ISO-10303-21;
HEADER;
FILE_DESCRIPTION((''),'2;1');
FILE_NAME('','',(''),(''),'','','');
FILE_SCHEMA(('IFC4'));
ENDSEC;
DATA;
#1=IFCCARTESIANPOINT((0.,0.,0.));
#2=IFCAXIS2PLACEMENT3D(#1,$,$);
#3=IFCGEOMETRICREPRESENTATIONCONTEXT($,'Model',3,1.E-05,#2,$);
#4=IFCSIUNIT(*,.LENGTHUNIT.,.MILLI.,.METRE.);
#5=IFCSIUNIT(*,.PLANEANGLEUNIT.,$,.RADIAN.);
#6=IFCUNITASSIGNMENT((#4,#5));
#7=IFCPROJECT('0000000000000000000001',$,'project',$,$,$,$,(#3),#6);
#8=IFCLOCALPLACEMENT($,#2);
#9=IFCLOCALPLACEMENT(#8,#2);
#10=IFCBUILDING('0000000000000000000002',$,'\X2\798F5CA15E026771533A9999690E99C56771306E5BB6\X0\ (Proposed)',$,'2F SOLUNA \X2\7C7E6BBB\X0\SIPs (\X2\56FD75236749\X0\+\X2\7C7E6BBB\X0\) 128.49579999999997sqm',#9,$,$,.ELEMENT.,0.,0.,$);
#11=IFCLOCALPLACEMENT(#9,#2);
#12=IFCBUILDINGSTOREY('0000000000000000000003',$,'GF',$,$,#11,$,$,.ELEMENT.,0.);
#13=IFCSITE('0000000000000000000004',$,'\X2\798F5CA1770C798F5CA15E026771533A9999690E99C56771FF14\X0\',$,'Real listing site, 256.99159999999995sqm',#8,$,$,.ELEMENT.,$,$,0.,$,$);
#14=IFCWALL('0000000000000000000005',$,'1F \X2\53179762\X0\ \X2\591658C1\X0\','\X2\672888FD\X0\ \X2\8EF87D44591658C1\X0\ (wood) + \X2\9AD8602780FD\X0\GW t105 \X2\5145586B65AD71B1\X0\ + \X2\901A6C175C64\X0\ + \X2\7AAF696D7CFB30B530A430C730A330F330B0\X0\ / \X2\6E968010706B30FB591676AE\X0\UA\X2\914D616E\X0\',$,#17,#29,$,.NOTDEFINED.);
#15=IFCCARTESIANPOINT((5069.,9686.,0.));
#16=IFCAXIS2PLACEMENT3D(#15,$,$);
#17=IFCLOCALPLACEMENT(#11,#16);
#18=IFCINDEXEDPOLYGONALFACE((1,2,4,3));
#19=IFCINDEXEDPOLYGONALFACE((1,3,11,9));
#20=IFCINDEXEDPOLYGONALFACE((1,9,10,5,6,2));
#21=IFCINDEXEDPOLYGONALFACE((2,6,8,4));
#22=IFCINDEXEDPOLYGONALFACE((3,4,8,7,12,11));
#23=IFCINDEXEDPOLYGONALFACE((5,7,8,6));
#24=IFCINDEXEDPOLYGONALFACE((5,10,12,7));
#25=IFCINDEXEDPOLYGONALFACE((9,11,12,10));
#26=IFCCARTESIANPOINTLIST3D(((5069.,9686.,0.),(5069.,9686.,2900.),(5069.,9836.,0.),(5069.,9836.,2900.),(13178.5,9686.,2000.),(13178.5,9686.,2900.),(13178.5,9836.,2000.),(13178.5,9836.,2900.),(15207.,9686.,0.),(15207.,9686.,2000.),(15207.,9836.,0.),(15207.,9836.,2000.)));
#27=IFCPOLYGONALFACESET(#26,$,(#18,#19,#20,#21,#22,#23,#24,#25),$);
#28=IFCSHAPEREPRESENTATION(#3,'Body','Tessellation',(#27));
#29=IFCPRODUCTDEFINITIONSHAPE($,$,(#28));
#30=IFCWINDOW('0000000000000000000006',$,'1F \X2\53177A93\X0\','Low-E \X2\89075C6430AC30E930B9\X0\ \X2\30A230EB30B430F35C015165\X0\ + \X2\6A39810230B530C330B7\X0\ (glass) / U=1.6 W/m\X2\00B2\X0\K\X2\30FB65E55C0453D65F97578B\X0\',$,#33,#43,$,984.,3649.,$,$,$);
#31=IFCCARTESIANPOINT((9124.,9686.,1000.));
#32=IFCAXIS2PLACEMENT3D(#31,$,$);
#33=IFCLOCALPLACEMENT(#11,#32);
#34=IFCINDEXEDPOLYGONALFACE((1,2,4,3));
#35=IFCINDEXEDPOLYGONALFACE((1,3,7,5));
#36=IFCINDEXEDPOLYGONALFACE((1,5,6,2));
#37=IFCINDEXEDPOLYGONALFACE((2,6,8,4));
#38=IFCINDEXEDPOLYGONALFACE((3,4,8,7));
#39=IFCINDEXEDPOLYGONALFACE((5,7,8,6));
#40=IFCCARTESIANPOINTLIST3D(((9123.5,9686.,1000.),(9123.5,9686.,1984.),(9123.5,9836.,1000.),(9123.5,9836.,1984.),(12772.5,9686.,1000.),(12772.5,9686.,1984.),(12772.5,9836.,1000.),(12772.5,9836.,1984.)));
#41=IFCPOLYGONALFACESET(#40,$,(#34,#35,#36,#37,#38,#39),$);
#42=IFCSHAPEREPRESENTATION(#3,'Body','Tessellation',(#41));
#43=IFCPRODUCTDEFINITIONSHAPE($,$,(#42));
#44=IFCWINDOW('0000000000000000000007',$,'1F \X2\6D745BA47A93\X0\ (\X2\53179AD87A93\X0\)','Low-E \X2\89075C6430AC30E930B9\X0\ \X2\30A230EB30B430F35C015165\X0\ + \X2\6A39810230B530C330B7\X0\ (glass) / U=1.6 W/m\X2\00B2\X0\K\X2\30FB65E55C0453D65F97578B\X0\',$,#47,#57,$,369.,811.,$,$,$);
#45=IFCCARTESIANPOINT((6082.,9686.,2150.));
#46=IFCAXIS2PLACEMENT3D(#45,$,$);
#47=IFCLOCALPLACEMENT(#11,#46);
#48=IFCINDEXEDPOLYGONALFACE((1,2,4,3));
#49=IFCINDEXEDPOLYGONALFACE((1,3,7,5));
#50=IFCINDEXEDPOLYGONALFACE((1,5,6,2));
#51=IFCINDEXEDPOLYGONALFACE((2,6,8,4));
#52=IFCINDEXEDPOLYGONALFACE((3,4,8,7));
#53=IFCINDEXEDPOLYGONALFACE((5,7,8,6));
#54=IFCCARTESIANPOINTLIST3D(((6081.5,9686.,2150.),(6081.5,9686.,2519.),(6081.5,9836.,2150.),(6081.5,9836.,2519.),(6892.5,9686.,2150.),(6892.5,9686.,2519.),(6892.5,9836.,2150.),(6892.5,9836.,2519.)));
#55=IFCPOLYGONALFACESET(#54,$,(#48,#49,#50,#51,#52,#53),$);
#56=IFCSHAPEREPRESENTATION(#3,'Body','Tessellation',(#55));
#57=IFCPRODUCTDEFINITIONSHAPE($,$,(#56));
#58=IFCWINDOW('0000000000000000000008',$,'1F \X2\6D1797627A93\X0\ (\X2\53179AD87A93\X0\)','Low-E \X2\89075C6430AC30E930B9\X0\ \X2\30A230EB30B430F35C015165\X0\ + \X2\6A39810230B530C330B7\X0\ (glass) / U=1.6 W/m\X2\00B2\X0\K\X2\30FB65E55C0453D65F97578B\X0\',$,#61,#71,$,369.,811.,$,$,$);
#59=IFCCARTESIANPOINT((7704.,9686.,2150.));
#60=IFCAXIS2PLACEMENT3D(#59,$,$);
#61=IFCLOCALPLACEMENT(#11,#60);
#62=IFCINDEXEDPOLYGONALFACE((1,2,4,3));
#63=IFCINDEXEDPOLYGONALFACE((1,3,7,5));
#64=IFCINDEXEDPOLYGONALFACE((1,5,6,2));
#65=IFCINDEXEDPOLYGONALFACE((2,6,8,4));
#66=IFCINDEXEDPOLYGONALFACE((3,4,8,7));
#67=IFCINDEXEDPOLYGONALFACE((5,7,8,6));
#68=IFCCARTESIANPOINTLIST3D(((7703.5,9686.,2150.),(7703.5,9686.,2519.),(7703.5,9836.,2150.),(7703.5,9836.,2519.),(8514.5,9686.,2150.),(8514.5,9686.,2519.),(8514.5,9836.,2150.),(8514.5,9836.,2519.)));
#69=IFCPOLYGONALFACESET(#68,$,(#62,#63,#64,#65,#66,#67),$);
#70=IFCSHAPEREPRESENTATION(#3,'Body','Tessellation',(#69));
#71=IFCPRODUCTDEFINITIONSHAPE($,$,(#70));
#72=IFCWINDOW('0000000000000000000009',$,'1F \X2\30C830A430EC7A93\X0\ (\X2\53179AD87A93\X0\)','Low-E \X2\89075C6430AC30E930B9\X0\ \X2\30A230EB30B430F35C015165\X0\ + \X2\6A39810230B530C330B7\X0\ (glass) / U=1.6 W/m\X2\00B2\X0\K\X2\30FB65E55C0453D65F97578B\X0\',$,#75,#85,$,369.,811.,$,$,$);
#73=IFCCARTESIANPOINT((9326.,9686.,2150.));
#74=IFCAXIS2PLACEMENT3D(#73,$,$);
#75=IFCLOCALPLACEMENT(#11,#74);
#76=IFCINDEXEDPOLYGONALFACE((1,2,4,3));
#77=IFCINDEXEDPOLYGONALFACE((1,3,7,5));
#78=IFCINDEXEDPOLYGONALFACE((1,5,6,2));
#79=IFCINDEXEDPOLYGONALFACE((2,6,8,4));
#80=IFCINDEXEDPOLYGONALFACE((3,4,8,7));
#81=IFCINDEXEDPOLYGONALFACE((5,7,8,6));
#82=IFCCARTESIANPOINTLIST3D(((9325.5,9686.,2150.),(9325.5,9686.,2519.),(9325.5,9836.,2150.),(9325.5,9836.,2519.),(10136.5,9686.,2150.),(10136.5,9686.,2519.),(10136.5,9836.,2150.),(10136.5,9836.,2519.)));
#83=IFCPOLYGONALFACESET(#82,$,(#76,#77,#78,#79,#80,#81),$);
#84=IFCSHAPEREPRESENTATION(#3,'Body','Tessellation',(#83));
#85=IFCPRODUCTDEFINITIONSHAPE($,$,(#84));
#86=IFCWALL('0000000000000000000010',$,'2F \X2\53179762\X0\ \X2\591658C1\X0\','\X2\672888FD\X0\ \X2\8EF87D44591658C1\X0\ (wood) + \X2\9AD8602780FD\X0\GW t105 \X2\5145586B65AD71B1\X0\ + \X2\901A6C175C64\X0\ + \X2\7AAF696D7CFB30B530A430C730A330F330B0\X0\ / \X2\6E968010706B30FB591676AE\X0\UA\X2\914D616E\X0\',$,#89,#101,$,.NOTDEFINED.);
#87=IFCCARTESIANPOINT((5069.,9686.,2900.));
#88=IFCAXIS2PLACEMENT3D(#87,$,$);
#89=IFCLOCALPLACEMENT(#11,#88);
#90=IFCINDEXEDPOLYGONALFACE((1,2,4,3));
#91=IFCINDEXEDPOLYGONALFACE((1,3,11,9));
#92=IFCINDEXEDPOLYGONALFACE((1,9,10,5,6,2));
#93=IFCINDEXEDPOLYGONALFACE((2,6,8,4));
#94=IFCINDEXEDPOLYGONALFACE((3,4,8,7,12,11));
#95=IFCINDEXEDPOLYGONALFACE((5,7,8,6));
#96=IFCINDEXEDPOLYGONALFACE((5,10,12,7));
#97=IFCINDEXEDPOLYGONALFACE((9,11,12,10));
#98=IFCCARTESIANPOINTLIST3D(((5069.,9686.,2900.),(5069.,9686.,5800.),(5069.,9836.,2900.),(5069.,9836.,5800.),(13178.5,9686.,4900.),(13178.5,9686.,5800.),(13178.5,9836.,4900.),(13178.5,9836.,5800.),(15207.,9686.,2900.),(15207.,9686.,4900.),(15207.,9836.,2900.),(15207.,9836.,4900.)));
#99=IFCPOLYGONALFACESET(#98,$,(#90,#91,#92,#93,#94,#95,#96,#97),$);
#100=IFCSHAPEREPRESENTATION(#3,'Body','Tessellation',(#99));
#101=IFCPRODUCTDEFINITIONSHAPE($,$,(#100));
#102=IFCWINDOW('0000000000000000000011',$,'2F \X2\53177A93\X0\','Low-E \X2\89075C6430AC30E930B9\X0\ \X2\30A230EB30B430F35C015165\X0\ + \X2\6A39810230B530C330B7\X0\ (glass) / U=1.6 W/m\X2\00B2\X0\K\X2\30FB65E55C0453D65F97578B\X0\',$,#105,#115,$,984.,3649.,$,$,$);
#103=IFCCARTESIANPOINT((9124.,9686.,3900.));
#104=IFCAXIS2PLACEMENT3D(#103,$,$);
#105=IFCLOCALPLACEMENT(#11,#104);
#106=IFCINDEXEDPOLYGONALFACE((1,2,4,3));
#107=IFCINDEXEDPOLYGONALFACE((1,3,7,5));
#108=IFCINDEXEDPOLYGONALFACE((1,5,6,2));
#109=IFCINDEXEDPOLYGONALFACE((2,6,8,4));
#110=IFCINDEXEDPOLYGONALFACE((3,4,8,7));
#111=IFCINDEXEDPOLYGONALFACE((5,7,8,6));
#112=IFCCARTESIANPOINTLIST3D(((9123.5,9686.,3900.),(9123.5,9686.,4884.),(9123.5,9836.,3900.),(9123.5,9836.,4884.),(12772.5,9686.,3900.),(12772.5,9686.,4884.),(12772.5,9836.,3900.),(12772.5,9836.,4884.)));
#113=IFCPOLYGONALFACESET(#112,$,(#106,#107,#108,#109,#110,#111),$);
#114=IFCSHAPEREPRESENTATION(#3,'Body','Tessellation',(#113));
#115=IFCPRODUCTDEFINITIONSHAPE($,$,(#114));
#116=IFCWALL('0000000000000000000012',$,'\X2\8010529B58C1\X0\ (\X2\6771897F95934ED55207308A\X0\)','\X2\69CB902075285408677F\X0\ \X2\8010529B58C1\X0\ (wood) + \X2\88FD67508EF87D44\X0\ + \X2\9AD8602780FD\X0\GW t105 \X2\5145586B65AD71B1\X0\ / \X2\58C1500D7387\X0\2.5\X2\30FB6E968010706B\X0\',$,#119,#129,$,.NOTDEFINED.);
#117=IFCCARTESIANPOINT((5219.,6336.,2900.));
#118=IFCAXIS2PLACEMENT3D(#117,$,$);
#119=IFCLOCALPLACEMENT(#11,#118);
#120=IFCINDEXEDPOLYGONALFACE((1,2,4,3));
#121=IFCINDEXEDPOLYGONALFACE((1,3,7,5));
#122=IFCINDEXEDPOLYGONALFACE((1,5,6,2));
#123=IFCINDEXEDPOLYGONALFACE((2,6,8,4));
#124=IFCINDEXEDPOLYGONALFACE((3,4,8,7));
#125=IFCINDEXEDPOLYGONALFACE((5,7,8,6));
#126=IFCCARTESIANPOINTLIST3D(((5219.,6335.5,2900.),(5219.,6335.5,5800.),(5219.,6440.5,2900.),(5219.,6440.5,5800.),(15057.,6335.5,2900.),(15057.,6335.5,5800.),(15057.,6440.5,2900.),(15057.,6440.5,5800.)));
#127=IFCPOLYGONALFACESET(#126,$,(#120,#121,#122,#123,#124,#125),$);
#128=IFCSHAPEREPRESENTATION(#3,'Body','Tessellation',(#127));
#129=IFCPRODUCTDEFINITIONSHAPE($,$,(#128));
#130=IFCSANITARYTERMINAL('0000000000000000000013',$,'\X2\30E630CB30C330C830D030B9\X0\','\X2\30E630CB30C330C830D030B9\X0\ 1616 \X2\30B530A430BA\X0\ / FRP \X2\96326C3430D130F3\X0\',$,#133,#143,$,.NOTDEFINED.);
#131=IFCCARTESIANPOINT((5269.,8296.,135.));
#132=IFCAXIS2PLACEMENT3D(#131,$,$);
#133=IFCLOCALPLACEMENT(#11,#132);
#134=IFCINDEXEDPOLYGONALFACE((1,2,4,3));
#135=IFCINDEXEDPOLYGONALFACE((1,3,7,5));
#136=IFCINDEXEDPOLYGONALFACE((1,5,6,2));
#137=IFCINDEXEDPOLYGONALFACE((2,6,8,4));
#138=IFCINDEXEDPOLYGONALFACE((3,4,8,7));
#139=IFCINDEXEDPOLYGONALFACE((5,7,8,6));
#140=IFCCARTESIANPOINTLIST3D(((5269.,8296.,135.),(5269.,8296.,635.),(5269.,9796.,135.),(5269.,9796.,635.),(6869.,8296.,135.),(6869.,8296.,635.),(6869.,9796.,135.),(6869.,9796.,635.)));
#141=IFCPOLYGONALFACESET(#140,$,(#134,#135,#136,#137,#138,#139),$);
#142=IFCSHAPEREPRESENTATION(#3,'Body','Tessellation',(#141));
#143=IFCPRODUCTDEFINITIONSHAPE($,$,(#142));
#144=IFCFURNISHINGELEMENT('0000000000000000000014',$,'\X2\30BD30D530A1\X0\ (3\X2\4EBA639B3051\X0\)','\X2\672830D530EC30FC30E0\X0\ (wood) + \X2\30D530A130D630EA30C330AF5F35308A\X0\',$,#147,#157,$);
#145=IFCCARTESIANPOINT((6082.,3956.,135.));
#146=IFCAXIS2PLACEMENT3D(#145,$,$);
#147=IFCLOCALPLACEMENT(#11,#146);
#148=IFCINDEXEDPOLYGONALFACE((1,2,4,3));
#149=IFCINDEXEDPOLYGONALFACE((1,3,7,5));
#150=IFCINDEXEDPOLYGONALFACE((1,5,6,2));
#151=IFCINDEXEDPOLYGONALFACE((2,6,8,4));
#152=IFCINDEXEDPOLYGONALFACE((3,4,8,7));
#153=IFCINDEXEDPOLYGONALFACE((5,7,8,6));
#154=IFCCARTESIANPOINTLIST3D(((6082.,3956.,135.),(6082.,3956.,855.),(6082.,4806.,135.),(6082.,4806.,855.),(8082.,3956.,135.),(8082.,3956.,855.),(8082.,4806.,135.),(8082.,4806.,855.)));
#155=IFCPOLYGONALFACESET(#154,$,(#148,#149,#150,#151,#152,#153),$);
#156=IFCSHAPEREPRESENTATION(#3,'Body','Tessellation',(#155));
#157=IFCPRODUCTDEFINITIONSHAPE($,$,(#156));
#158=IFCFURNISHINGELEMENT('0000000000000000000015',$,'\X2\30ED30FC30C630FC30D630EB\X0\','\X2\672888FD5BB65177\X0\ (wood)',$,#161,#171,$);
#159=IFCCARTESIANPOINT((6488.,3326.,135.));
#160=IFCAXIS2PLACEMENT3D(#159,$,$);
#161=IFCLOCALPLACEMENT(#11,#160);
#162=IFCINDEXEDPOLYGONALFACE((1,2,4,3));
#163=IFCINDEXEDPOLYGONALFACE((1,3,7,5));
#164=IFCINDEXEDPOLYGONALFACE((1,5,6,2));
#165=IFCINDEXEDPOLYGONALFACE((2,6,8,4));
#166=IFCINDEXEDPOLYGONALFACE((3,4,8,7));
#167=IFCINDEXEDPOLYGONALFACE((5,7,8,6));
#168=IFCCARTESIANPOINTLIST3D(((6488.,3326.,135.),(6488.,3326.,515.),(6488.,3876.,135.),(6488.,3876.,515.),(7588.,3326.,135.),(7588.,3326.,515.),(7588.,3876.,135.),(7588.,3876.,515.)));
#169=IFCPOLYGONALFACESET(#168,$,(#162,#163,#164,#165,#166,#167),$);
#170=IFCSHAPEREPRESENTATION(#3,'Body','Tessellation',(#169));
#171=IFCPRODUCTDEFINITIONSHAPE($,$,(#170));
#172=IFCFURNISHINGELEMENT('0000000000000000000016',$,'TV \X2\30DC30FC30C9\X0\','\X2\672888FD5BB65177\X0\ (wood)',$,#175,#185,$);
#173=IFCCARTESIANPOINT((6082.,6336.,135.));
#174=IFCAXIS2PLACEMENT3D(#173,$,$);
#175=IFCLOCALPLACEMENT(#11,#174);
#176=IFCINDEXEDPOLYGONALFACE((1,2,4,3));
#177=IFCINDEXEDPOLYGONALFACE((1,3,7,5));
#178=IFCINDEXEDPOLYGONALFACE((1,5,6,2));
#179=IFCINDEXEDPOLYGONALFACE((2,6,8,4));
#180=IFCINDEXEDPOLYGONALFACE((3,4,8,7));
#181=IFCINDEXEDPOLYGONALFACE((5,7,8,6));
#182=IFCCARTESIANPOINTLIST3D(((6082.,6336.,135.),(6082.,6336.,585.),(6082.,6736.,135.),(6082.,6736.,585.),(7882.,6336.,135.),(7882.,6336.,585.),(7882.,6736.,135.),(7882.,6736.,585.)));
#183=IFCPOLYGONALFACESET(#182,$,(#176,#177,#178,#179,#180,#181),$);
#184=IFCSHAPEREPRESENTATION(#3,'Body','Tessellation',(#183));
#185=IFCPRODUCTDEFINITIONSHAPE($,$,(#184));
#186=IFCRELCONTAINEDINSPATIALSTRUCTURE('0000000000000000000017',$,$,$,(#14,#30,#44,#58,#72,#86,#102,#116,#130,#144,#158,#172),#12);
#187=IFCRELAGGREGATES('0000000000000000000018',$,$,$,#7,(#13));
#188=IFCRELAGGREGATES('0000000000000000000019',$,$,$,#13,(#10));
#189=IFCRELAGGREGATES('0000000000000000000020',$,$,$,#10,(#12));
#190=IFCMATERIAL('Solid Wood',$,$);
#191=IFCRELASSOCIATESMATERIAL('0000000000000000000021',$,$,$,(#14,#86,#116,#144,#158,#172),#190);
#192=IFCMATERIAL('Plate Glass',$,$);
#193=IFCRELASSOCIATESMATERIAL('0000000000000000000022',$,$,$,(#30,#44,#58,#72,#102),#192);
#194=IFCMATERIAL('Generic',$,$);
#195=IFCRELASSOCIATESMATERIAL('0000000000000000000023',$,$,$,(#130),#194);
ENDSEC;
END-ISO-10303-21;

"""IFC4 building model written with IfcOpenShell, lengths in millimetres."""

from ifc_helpers import new_model, si_unit, frame, frame_2d, origin, place, context, project, spatial, rectangle, extrude, material, element, fill, save


model = new_model("IFC4")

# Units and contexts
model_context = context("Model", 3, precision=1e-05, world=origin())
ifc_project = project(units=[si_unit("LENGTHUNIT", "METRE", prefix="MILLI"), si_unit("PLANEANGLEUNIT", "RADIAN")], contexts=[model_context])

# Site, building, storey
site_placement = place(None, origin())
site = spatial("IfcSite", under=ifc_project, at=site_placement, Name="福岡県福岡市東区香椎駅東４", ObjectType="Real listing site, 256.99159999999995sqm", CompositionType="ELEMENT", RefElevation=0.0)
building_placement = place(site_placement, origin())
building = spatial("IfcBuilding", under=site, at=building_placement, Name="福岡市東区香椎駅東の家 (Proposed)", ObjectType="2F SOLUNA 籾殻SIPs (国産杉+籾殻) 128.49579999999997sqm", CompositionType="ELEMENT", ElevationOfRefHeight=0.0, ElevationOfTerrain=0.0)
storey_placement = place(building_placement, origin())
storey = spatial("IfcBuildingStorey", under=building, at=storey_placement, Name="GF", CompositionType="ELEMENT", Elevation=0.0)

# Wall, openings, windows
ifc_material_1 = material(Name="Solid Wood")
wall_1_placement = place(storey_placement, frame((5069.0, 9686.0, 0.0)))
wall_1 = element("IfcWall", 1, at=wall_1_placement, inside=storey, material=ifc_material_1, Name="1F 北面 外壁", Description="木製 軸組外壁 (wood) + 高性能GW t105 充填断熱 + 通気層 + 窯業系サイディング / 準耐火・外皮UA配慮", PredefinedType="NOTDEFINED", context=model_context, shape_type="SweptSolid", body=[
    extrude(rectangle(XDim=10138.0, YDim=150.0, at=frame_2d((5069.0, 75.0))), frame((5069.0, 9686.0, 0.0)), (0.0, 0.0, 1.0), 2900.0),
])
opening_1_placement = place(storey_placement, frame((9124.0, 9686.0, 1000.0)))
opening_1 = element("IfcOpeningElement", 2, at=opening_1_placement, cuts=wall_1, PredefinedType="NOTDEFINED", context=model_context, shape_type="SweptSolid", body=[
    extrude(rectangle(XDim=3649.0, YDim=150.0, at=frame_2d((1824.0, 75.0))), frame((9124.0, 9686.0, 1000.0)), (0.0, 0.0, 1.0), 984.0),
])
opening_2_placement = place(storey_placement, frame((6082.0, 9686.0, 2150.0)))
opening_2 = element("IfcOpeningElement", 3, at=opening_2_placement, cuts=wall_1, PredefinedType="NOTDEFINED", context=model_context, shape_type="SweptSolid", body=[
    extrude(rectangle(XDim=811.0, YDim=150.0, at=frame_2d((405.0, 75.0))), frame((6082.0, 9686.0, 2150.0)), (0.0, 0.0, 1.0), 369.0),
])
opening_3_placement = place(storey_placement, frame((7704.0, 9686.0, 2150.0)))
opening_3 = element("IfcOpeningElement", 4, at=opening_3_placement, cuts=wall_1, PredefinedType="NOTDEFINED", context=model_context, shape_type="SweptSolid", body=[
    extrude(rectangle(XDim=811.0, YDim=150.0, at=frame_2d((405.0, 75.0))), frame((7704.0, 9686.0, 2150.0)), (0.0, 0.0, 1.0), 369.0),
])
opening_4_placement = place(storey_placement, frame((9326.0, 9686.0, 2150.0)))
opening_4 = element("IfcOpeningElement", 5, at=opening_4_placement, cuts=wall_1, PredefinedType="NOTDEFINED", context=model_context, shape_type="SweptSolid", body=[
    extrude(rectangle(XDim=811.0, YDim=150.0, at=frame_2d((405.0, 75.0))), frame((9326.0, 9686.0, 2150.0)), (0.0, 0.0, 1.0), 369.0),
])
ifc_material_2 = material(Name="Plate Glass")
window_1_placement = place(storey_placement, frame((9124.0, 9686.0, 1000.0)))
window_1 = element("IfcWindow", 6, at=window_1_placement, inside=storey, material=ifc_material_2, Name="1F 北窓", Description="Low-E 複層ガラス アルゴン封入 + 樹脂サッシ (glass) / U=1.6 W/m²K・日射取得型", OverallHeight=984.0, OverallWidth=3649.0, context=model_context, shape_type="SweptSolid", body=[
    extrude(rectangle(XDim=3649.0, YDim=150.0, at=frame_2d((1824.0, 75.0))), frame((9124.0, 9686.0, 1000.0)), (0.0, 0.0, 1.0), 984.0),
])
fill(opening_1, window_1)
window_2_placement = place(storey_placement, frame((6082.0, 9686.0, 2150.0)))
window_2 = element("IfcWindow", 7, at=window_2_placement, inside=storey, material=ifc_material_2, Name="1F 浴室窓 (北高窓)", Description="Low-E 複層ガラス アルゴン封入 + 樹脂サッシ (glass) / U=1.6 W/m²K・日射取得型", OverallHeight=369.0, OverallWidth=811.0, context=model_context, shape_type="SweptSolid", body=[
    extrude(rectangle(XDim=811.0, YDim=150.0, at=frame_2d((405.0, 75.0))), frame((6082.0, 9686.0, 2150.0)), (0.0, 0.0, 1.0), 369.0),
])
fill(opening_2, window_2)
window_3_placement = place(storey_placement, frame((7704.0, 9686.0, 2150.0)))
window_3 = element("IfcWindow", 8, at=window_3_placement, inside=storey, material=ifc_material_2, Name="1F 洗面窓 (北高窓)", Description="Low-E 複層ガラス アルゴン封入 + 樹脂サッシ (glass) / U=1.6 W/m²K・日射取得型", OverallHeight=369.0, OverallWidth=811.0, context=model_context, shape_type="SweptSolid", body=[
    extrude(rectangle(XDim=811.0, YDim=150.0, at=frame_2d((405.0, 75.0))), frame((7704.0, 9686.0, 2150.0)), (0.0, 0.0, 1.0), 369.0),
])
fill(opening_3, window_3)
window_4_placement = place(storey_placement, frame((9326.0, 9686.0, 2150.0)))
window_4 = element("IfcWindow", 9, at=window_4_placement, inside=storey, material=ifc_material_2, Name="1F トイレ窓 (北高窓)", Description="Low-E 複層ガラス アルゴン封入 + 樹脂サッシ (glass) / U=1.6 W/m²K・日射取得型", OverallHeight=369.0, OverallWidth=811.0, context=model_context, shape_type="SweptSolid", body=[
    extrude(rectangle(XDim=811.0, YDim=150.0, at=frame_2d((405.0, 75.0))), frame((9326.0, 9686.0, 2150.0)), (0.0, 0.0, 1.0), 369.0),
])
fill(opening_4, window_4)

# Wall, opening, window
wall_2_placement = place(storey_placement, frame((5069.0, 9686.0, 2900.0)))
wall_2 = element("IfcWall", 10, at=wall_2_placement, inside=storey, material=ifc_material_1, Name="2F 北面 外壁", Description="木製 軸組外壁 (wood) + 高性能GW t105 充填断熱 + 通気層 + 窯業系サイディング / 準耐火・外皮UA配慮", PredefinedType="NOTDEFINED", context=model_context, shape_type="SweptSolid", body=[
    extrude(rectangle(XDim=10138.0, YDim=150.0, at=frame_2d((5069.0, 75.0))), frame((5069.0, 9686.0, 2900.0)), (0.0, 0.0, 1.0), 2900.0),
])
opening_5_placement = place(storey_placement, frame((9124.0, 9686.0, 3900.0)))
opening_5 = element("IfcOpeningElement", 11, at=opening_5_placement, cuts=wall_2, PredefinedType="NOTDEFINED", context=model_context, shape_type="SweptSolid", body=[
    extrude(rectangle(XDim=3649.0, YDim=150.0, at=frame_2d((1824.0, 75.0))), frame((9124.0, 9686.0, 3900.0)), (0.0, 0.0, 1.0), 984.0),
])
window_5_placement = place(storey_placement, frame((9124.0, 9686.0, 3900.0)))
window_5 = element("IfcWindow", 12, at=window_5_placement, inside=storey, material=ifc_material_2, Name="2F 北窓", Description="Low-E 複層ガラス アルゴン封入 + 樹脂サッシ (glass) / U=1.6 W/m²K・日射取得型", OverallHeight=984.0, OverallWidth=3649.0, context=model_context, shape_type="SweptSolid", body=[
    extrude(rectangle(XDim=3649.0, YDim=150.0, at=frame_2d((1824.0, 75.0))), frame((9124.0, 9686.0, 3900.0)), (0.0, 0.0, 1.0), 984.0),
])
fill(opening_5, window_5)

# Wall
wall_3_placement = place(storey_placement, frame((5219.0, 6336.0, 2900.0)))
element("IfcWall", 13, at=wall_3_placement, inside=storey, material=ifc_material_1, Name="耐力壁 (東西間仕切り)", Description="構造用合板 耐力壁 (wood) + 製材軸組 + 高性能GW t105 充填断熱 / 壁倍率2.5・準耐火", PredefinedType="NOTDEFINED", context=model_context, shape_type="SweptSolid", body=[
    extrude(rectangle(XDim=9838.0, YDim=105.0, at=frame_2d((4919.0, 52.0))), frame((5219.0, 6336.0, 2900.0)), (0.0, 0.0, 1.0), 2900.0),
])

# Sanitary terminal
ifc_material_3 = material(Name="Generic")
sanitary_terminal_placement = place(storey_placement, frame((5269.0, 8296.0, 135.0)))
element("IfcSanitaryTerminal", 14, at=sanitary_terminal_placement, inside=storey, material=ifc_material_3, Name="ユニットバス", Description="ユニットバス 1616 サイズ / FRP 防水パン", PredefinedType="NOTDEFINED", context=model_context, shape_type="SweptSolid", body=[
    extrude(rectangle(XDim=1600.0, YDim=1500.0, at=frame_2d((800.0, 750.0))), frame((5269.0, 8296.0, 135.0)), (0.0, 0.0, 1.0), 500.0),
])

# Furnishing elements
furnishing_1_placement = place(storey_placement, frame((6082.0, 3956.0, 135.0)))
element("IfcFurnishingElement", 15, at=furnishing_1_placement, inside=storey, material=ifc_material_1, Name="ソファ (3人掛け)", Description="木フレーム (wood) + ファブリック張り", context=model_context, shape_type="SweptSolid", body=[
    extrude(rectangle(XDim=2000.0, YDim=850.0, at=frame_2d((1000.0, 425.0))), frame((6082.0, 3956.0, 135.0)), (0.0, 0.0, 1.0), 720.0),
])
furnishing_2_placement = place(storey_placement, frame((6488.0, 3326.0, 135.0)))
element("IfcFurnishingElement", 16, at=furnishing_2_placement, inside=storey, material=ifc_material_1, Name="ローテーブル", Description="木製家具 (wood)", context=model_context, shape_type="SweptSolid", body=[
    extrude(rectangle(XDim=1100.0, YDim=550.0, at=frame_2d((550.0, 275.0))), frame((6488.0, 3326.0, 135.0)), (0.0, 0.0, 1.0), 380.0),
])
furnishing_3_placement = place(storey_placement, frame((6082.0, 6336.0, 135.0)))
element("IfcFurnishingElement", 17, at=furnishing_3_placement, inside=storey, material=ifc_material_1, Name="TV ボード", Description="木製家具 (wood)", context=model_context, shape_type="SweptSolid", body=[
    extrude(rectangle(XDim=1800.0, YDim=400.0, at=frame_2d((900.0, 200.0))), frame((6082.0, 6336.0, 135.0)), (0.0, 0.0, 1.0), 450.0),
])

save(model, "model.ifc")
